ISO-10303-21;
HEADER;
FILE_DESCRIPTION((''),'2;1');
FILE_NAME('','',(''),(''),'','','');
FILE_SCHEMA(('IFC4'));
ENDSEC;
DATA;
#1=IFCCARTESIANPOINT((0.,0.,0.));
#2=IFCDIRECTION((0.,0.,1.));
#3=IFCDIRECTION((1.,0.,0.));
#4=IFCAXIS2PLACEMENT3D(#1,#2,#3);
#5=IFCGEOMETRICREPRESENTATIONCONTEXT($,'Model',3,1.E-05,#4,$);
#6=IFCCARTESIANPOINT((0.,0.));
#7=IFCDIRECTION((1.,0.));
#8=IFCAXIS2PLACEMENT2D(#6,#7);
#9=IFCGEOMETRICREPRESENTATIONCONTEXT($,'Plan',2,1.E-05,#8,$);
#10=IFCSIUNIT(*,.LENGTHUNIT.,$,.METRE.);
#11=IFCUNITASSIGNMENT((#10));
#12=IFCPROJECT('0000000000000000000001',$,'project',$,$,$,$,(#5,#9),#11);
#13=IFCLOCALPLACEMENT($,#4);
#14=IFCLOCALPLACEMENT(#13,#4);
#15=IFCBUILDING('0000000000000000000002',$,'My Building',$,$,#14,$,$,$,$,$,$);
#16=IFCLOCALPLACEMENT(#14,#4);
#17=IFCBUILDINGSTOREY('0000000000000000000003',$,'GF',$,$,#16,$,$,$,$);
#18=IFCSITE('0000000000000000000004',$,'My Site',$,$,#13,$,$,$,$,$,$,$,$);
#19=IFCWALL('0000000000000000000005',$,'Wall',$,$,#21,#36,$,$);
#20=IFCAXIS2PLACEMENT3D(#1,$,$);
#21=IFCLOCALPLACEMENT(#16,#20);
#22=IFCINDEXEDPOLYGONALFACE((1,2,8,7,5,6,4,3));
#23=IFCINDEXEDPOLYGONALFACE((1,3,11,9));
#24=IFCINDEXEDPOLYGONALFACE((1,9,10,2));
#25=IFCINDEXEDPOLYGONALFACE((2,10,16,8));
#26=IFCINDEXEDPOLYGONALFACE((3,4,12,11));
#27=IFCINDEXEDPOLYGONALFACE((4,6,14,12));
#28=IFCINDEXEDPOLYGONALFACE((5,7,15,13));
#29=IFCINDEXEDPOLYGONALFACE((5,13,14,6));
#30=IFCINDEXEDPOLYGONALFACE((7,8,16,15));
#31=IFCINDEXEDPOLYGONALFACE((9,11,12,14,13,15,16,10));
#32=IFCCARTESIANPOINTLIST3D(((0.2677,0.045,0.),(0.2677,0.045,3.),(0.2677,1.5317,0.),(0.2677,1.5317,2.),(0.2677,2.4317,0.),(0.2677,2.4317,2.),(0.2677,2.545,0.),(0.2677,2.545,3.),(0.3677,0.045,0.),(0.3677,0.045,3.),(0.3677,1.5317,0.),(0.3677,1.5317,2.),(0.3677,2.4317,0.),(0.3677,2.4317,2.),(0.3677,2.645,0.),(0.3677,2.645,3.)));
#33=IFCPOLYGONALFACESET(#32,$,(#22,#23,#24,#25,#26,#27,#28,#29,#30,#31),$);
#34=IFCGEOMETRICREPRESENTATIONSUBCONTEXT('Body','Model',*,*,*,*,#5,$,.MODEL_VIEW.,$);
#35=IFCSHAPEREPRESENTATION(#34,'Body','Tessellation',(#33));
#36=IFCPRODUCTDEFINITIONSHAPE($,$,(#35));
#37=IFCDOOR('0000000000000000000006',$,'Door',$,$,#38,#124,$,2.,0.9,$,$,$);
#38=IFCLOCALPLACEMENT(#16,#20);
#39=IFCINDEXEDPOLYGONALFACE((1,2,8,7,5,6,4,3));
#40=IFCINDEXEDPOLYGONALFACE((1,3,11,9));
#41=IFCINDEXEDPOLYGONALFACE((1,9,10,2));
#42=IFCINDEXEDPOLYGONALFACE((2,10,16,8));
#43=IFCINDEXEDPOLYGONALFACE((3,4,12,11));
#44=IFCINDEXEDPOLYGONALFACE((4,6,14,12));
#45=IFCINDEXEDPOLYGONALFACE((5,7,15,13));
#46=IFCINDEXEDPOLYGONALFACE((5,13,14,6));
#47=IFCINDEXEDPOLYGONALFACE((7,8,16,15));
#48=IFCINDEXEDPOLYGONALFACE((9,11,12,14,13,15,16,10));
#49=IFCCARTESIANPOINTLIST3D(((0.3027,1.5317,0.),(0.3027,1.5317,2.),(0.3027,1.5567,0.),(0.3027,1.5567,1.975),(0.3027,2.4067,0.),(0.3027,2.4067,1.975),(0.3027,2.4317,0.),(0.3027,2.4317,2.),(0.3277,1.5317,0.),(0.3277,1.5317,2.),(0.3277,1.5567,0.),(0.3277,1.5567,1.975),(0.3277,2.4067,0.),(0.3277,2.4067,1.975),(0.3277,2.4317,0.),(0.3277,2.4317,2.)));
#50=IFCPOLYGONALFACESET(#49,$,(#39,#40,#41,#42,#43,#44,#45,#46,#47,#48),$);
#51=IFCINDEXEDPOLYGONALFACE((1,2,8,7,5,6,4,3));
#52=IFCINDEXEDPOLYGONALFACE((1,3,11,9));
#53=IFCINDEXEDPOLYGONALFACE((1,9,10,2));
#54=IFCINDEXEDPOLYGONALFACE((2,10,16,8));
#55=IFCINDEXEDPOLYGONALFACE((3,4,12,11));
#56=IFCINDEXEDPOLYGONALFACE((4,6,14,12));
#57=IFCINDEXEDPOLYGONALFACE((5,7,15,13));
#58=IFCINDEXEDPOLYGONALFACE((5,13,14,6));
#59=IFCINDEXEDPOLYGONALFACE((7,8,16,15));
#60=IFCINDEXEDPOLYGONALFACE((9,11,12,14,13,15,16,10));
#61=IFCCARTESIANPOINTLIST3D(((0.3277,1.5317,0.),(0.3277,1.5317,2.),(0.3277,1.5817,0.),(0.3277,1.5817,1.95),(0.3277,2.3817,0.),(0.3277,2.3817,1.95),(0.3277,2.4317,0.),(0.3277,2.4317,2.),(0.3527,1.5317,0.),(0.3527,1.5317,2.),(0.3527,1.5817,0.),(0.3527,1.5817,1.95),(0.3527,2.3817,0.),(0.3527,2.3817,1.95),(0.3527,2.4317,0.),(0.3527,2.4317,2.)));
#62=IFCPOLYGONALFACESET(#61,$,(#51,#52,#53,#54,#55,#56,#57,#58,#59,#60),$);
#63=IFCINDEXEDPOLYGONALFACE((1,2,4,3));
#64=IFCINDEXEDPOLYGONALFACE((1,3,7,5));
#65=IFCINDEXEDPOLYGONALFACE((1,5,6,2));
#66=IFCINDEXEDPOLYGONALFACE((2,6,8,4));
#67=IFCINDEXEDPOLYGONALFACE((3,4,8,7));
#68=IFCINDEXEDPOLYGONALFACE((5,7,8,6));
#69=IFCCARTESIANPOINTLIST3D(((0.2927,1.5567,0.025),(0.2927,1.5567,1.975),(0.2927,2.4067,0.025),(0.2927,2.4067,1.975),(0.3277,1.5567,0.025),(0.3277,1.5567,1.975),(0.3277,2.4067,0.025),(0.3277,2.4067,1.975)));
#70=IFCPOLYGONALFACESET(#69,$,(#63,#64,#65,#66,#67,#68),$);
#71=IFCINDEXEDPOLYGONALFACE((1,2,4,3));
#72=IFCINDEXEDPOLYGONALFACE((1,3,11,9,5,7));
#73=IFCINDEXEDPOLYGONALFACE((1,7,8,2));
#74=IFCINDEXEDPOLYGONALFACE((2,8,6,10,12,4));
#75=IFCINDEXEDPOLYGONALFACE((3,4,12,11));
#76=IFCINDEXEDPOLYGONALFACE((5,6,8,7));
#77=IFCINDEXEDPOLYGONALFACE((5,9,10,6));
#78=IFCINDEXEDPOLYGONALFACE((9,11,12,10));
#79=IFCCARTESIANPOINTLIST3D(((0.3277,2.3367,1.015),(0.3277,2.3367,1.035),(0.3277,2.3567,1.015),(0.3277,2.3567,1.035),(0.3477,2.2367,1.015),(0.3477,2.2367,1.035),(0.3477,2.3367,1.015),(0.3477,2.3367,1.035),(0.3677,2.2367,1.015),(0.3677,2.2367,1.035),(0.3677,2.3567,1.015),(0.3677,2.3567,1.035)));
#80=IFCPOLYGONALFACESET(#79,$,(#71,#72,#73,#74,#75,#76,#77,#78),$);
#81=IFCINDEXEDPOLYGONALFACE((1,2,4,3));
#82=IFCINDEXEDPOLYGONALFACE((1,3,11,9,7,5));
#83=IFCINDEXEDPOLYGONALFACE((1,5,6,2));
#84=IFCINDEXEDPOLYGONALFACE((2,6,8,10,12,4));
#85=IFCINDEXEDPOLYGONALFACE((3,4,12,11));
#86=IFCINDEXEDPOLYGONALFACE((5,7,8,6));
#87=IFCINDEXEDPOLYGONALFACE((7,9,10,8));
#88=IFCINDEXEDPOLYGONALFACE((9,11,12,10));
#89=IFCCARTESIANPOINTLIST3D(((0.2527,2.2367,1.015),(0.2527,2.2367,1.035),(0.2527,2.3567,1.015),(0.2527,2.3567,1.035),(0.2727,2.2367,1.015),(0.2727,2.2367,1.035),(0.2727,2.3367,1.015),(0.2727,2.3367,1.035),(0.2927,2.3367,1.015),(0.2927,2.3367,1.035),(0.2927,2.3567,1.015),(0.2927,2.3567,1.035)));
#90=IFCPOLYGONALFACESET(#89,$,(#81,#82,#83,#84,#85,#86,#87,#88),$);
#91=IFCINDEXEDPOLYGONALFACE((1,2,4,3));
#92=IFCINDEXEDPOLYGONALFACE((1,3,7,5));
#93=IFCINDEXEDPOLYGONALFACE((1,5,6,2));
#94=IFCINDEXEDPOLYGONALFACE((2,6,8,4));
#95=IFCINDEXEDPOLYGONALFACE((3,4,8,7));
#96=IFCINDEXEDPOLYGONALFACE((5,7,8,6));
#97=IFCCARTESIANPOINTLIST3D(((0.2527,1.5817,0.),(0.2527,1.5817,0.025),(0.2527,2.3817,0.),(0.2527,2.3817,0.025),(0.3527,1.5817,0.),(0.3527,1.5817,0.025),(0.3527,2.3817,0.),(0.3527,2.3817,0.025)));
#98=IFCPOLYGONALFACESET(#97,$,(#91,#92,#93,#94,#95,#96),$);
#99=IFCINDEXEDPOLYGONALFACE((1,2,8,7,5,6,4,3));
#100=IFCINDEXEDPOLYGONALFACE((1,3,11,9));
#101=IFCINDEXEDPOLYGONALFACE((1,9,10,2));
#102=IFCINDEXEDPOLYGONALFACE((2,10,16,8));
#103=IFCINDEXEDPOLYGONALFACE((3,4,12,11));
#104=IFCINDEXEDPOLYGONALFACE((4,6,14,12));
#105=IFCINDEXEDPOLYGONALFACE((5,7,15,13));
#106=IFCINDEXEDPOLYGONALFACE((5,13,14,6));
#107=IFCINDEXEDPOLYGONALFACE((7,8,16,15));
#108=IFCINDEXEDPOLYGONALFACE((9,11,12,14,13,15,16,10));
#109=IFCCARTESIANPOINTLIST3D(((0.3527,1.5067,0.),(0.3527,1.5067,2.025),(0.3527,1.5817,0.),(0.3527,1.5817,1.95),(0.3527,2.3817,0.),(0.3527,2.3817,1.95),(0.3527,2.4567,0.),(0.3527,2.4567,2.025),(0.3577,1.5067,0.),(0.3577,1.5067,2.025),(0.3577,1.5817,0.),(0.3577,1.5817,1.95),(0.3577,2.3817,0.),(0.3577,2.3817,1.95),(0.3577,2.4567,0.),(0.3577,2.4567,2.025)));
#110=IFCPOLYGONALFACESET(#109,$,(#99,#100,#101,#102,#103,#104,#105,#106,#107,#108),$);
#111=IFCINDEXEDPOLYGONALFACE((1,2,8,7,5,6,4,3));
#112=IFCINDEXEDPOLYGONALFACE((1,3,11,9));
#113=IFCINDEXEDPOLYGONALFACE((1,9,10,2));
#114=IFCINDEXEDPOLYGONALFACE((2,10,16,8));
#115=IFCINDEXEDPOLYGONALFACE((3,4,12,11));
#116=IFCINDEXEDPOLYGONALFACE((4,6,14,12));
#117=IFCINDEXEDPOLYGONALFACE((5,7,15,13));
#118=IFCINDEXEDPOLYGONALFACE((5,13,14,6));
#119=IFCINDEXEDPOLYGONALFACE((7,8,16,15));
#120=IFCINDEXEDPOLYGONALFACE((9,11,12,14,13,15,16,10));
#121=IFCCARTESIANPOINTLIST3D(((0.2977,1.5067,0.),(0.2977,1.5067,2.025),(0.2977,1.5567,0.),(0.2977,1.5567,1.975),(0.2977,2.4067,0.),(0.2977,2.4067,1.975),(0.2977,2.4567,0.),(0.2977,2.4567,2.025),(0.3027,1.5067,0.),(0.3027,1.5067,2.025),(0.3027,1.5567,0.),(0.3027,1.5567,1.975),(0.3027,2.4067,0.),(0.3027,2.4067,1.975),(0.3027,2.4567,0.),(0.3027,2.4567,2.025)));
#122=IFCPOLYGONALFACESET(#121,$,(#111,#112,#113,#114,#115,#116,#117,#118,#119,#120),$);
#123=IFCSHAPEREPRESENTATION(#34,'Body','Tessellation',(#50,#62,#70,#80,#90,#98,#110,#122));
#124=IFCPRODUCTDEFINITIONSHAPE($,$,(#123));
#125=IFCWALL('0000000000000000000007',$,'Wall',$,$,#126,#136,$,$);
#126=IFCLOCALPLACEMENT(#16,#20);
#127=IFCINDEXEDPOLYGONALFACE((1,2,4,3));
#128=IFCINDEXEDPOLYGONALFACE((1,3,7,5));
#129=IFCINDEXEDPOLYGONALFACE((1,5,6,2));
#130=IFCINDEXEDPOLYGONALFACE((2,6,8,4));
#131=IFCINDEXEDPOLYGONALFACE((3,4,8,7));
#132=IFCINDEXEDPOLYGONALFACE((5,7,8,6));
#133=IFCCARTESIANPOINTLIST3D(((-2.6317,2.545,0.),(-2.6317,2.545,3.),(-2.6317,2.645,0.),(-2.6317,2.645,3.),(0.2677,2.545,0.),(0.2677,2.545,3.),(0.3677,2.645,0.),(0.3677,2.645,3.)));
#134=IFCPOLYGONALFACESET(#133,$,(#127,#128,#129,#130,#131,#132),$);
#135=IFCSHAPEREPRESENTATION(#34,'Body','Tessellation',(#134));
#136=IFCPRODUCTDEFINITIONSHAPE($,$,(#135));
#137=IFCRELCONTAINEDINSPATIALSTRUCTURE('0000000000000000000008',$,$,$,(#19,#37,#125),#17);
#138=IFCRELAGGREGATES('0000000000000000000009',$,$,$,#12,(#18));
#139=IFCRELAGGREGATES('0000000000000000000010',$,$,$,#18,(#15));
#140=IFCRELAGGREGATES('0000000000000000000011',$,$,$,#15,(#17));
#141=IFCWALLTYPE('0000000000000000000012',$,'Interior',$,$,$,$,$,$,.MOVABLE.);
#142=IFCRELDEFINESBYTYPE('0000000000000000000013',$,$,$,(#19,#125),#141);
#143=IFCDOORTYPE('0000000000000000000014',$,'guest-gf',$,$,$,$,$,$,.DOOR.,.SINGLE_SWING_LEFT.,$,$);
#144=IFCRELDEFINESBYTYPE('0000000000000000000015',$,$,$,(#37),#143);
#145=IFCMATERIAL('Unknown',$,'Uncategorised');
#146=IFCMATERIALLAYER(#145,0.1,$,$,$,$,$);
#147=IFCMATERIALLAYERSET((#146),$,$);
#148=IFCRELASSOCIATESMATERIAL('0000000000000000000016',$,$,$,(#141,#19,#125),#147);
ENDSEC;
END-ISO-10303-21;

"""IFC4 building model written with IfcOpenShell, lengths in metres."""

from ifc_helpers import new_model, entity, si_unit, frame, origin_with_axes, origin_2d_with_axis, place, context, subcontext, project, spatial, line, indexed_curve, outline, extrude, shape, source, transform, mapped, material, layer, layer_set, layer_usage, type_object, type_shapes, element, fill, save


model = new_model("IFC4")

# Units and contexts
model_context = context("Model", 3, precision=1e-05, world=origin_with_axes())
plan_context = context("Plan", 2, precision=1e-05, world=origin_2d_with_axis())
body_context_1 = subcontext(model_context, "Body", "Model", "MODEL_VIEW")
body_context_2 = subcontext(plan_context, "Body", "Plan", "PLAN_VIEW")
ifc_project = project(units=[si_unit("LENGTHUNIT", "METRE")], contexts=[model_context, plan_context])

# Site, building, storey
site_placement = place(None, origin_with_axes())
site = spatial("IfcSite", under=ifc_project, at=site_placement, Name="My Site")
building_placement = place(site_placement, origin_with_axes())
building = spatial("IfcBuilding", under=site, at=building_placement, Name="My Building")
storey_placement = place(building_placement, origin_with_axes())
storey = spatial("IfcBuildingStorey", under=building, at=storey_placement, Name="GF")

# Shared definitions
ifc_material = material(Name="Unknown", Category="Uncategorised")

# Shared definitions
ifc_layer_1 = layer(ifc_material, 0.1)
ifc_layer_set_1 = layer_set([ifc_layer_1])
wall_type_1 = type_object("IfcWallType", Name="Interior", PredefinedType="MOVABLE", material=ifc_layer_set_1)

# Wall, opening, door
ifc_layer_usage_1 = layer_usage(ifc_layer_set_1, "AXIS2", "POSITIVE", 0.0)
wall_1_placement = place(storey_placement, frame((0.3677, 0.045, 0.0), z_axis=(0.0, 0.0, 1.0), x_axis=(0.0, 1.0, 0.0)))
wall_1 = element("IfcWall", 1, at=wall_1_placement, inside=storey, type_object=wall_type_1, material=ifc_layer_usage_1, Name="Wall", context=body_context_1, shape_type="SweptSolid", body=[
    extrude(outline(indexed_curve([(0.0, 0.0), (0.0, 0.1), (2.5, 0.1), (2.6, 0.0)], segments=[line(1, 2, 3, 4, 1)])), origin_with_axes(), (0.0, 0.0, 1.0), 3.0),
])
shared_shape_1 = source(origin_with_axes(), body_context_1, "Body", "SweptSolid", [
    extrude(outline(indexed_curve([(0.0, 0.0), (0.9, 0.0), (0.9, 2.0), (0.0, 2.0)], segments=[line(1, 2, 3, 4, 1)])), frame((0.0, -0.6, 0.0), z_axis=(0.0, -1.0, 0.0), x_axis=(1.0, 0.0, 0.0)), (0.0, 0.0, -1.0), 1.2),
])
opening_1_placement = place(wall_1_placement, frame((1.4867, 0.015, 0.0), z_axis=(0.0, 0.0, 1.0), x_axis=(1.0, 0.0, 0.0)))
opening_1 = element("IfcOpeningElement", 2, at=opening_1_placement, cuts=wall_1, PredefinedType="OPENING", context=body_context_1, shape_type="MappedRepresentation", body=[
    mapped(shared_shape_1, transform((0.0, 0.0, 0.0), x_axis=(1.0, 0.0, 0.0), y_axis=(0.0, 1.0, 0.0), z_axis=(0.0, 0.0, 1.0), scale=1.0)),
])
door_type_1 = type_object("IfcDoorType", Name="guest-gf", OperationType="SINGLE_SWING_LEFT", PredefinedType="DOOR")
shared_shape_2 = source(origin_with_axes(), body_context_1, "Body", "SweptSolid", [
    extrude(outline(indexed_curve([(0.0, 0.0), (0.0, 2.0), (0.9, 2.0), (0.9, 0.0), (0.875, 0.0), (0.875, 1.975), (0.025, 1.975), (0.025, 0.0)], segments=[line(1, 2, 3, 4, 5, 6, 7, 8, 1)])), frame((0.0, 0.025, 0.0), z_axis=(0.0, -1.0, 0.0), x_axis=(1.0, 0.0, 0.0)), (0.0, 0.0, -1.0), 0.025),
    extrude(outline(indexed_curve([(0.0, 0.0), (0.0, 2.0), (0.9, 2.0), (0.9, 0.0), (0.85, 0.0), (0.85, 1.95), (0.05, 1.95), (0.05, 0.0)], segments=[line(1, 2, 3, 4, 5, 6, 7, 8, 1)])), frame((0.0, 0.0, 0.0), z_axis=(0.0, -1.0, 0.0), x_axis=(1.0, 0.0, 0.0)), (0.0, 0.0, -1.0), 0.025),
    extrude(outline(indexed_curve([(0.0, 0.0), (0.85, 0.0), (0.85, 0.035), (0.0, 0.035)], segments=[line(1, 2, 3, 4, 1)])), frame((0.025, 0.025, 0.025), z_axis=(0.0, 0.0, 1.0), x_axis=(1.0, 0.0, 0.0)), (0.0, 0.0, 1.0), 1.95),
    extrude(outline(indexed_curve([(0.0, 0.0), (0.0, -0.04), (-0.12, -0.04), (-0.12, -0.02), (-0.02, -0.02), (-0.02, 0.0)], segments=[line(1, 2, 3, 4, 5, 6, 1)])), frame((0.825, 0.025, 1.015), z_axis=(0.0, 0.0, 1.0), x_axis=(1.0, 0.0, 0.0)), (0.0, 0.0, 1.0), 0.02),
    extrude(outline(indexed_curve([(0.0, 0.0), (0.0, 0.04), (-0.12, 0.04), (-0.12, 0.02), (-0.02, 0.02), (-0.02, 0.0)], segments=[line(1, 2, 3, 4, 5, 6, 1)])), frame((0.825, 0.06, 1.015), z_axis=(0.0, 0.0, 1.0), x_axis=(1.0, 0.0, 0.0)), (0.0, 0.0, 1.0), 0.02),
    extrude(outline(indexed_curve([(0.0, 0.0), (0.8, 0.0), (0.8, 0.1), (0.0, 0.1)], segments=[line(1, 2, 3, 4, 1)])), frame((0.05, 0.0, 0.0), z_axis=(0.0, 0.0, 1.0), x_axis=(1.0, 0.0, 0.0)), (0.0, 0.0, 1.0), 0.025),
    extrude(outline(indexed_curve([(0.0, 0.0), (0.0, 2.025), (0.95, 2.025), (0.95, 0.0), (0.875, 0.0), (0.875, 1.95), (0.075, 1.95), (0.075, 0.0)], segments=[line(1, 2, 3, 4, 5, 6, 7, 8, 1)])), frame((-0.025, -0.005, 0.0), z_axis=(0.0, -1.0, 0.0), x_axis=(1.0, 0.0, 0.0)), (0.0, 0.0, -1.0), 0.005),
    extrude(outline(indexed_curve([(0.0, 0.0), (0.0, 2.025), (0.95, 2.025), (0.95, 0.0), (0.9, 0.0), (0.9, 1.975), (0.05, 1.975), (0.05, 0.0)], segments=[line(1, 2, 3, 4, 5, 6, 7, 8, 1)])), frame((-0.025, 0.05, 0.0), z_axis=(0.0, -1.0, 0.0), x_axis=(1.0, 0.0, 0.0)), (0.0, 0.0, -1.0), 0.005),
])
shared_shape_3 = source(origin_with_axes(), body_context_2, "Body", "Curve2D", [
    entity("IfcIndexedPolyCurve", entity("IfcCartesianPointList2D", [[0.0, 0.0], [0.0, 0.05], [0.025, 0.05], [0.025, 0.025], [0.05, 0.025], [0.05, 0.0]]), [entity("IfcLineIndex", [1, 2, 3, 4, 5, 6, 1])]),
    entity("IfcIndexedPolyCurve", entity("IfcCartesianPointList2D", [[0.9, 0.0], [0.9, 0.05], [0.875, 0.05], [0.875, 0.025], [0.85, 0.025], [0.85, 0.0]]), [entity("IfcLineIndex", [1, 2, 3, 4, 5, 6, 1])]),
    entity("IfcTrimmedCurve", entity("IfcEllipse", entity("IfcAxis2Placement2D", entity("IfcCartesianPoint", [0.06, 0.05]), entity("IfcDirection", [1.0, 0.0])), 0.815, 0.85), [entity("IfcCartesianPoint", [0.875, 0.05])], [entity("IfcCartesianPoint", [0.06, 0.9])], True, "CARTESIAN"),
    entity("IfcIndexedPolyCurve", entity("IfcCartesianPointList2D", [[0.025, 0.05], [0.06, 0.05], [0.06, 0.9], [0.025, 0.9]]), [entity("IfcLineIndex", [1, 2, 3, 4, 1])]),
])
type_shapes(door_type_1, [shared_shape_2, shared_shape_3])
door_1_placement = place(opening_1_placement, frame((0.0, 0.0, 0.0), z_axis=(0.0, 0.0, 1.0), x_axis=(1.0, 0.0, 0.0)))
door_1 = element("IfcDoor", 3, at=door_1_placement, inside=storey, type_object=door_type_1, Name="Door", OverallHeight=2.0, OverallWidth=0.9, shapes=[
    shape(body_context_1, "Body", "MappedRepresentation", [mapped(shared_shape_2, transform((0.0, 0.0, 0.0), x_axis=(1.0, 0.0, 0.0), y_axis=(0.0, 1.0, 0.0), z_axis=(0.0, 0.0, 1.0), scale=1.0))]),
    shape(body_context_2, "Body", "MappedRepresentation", [mapped(shared_shape_3, transform((0.0, 0.0, 0.0), x_axis=(1.0, 0.0, 0.0), y_axis=(0.0, 1.0, 0.0), z_axis=(0.0, 0.0, 1.0), scale=1.0))]),
])
fill(opening_1, door_1)

# Wall
ifc_layer_usage_2 = layer_usage(ifc_layer_set_1, "AXIS2", "POSITIVE", 0.0)
wall_2_placement = place(storey_placement, frame((0.3677, 2.645, 0.0), z_axis=(0.0, 0.0, 1.0), x_axis=(-1.0, 0.0, 0.0)))
element("IfcWall", 4, at=wall_2_placement, inside=storey, type_object=wall_type_1, material=ifc_layer_usage_2, Name="Wall", context=body_context_1, shape_type="SweptSolid", body=[
    extrude(outline(indexed_curve([(0.0, 0.0), (0.1, 0.1), (2.9994, 0.1), (2.9994, 0.0)], segments=[line(1, 2, 3, 4, 1)])), origin_with_axes(), (0.0, 0.0, 1.0), 3.0),
])

save(model, "model.ifc")
